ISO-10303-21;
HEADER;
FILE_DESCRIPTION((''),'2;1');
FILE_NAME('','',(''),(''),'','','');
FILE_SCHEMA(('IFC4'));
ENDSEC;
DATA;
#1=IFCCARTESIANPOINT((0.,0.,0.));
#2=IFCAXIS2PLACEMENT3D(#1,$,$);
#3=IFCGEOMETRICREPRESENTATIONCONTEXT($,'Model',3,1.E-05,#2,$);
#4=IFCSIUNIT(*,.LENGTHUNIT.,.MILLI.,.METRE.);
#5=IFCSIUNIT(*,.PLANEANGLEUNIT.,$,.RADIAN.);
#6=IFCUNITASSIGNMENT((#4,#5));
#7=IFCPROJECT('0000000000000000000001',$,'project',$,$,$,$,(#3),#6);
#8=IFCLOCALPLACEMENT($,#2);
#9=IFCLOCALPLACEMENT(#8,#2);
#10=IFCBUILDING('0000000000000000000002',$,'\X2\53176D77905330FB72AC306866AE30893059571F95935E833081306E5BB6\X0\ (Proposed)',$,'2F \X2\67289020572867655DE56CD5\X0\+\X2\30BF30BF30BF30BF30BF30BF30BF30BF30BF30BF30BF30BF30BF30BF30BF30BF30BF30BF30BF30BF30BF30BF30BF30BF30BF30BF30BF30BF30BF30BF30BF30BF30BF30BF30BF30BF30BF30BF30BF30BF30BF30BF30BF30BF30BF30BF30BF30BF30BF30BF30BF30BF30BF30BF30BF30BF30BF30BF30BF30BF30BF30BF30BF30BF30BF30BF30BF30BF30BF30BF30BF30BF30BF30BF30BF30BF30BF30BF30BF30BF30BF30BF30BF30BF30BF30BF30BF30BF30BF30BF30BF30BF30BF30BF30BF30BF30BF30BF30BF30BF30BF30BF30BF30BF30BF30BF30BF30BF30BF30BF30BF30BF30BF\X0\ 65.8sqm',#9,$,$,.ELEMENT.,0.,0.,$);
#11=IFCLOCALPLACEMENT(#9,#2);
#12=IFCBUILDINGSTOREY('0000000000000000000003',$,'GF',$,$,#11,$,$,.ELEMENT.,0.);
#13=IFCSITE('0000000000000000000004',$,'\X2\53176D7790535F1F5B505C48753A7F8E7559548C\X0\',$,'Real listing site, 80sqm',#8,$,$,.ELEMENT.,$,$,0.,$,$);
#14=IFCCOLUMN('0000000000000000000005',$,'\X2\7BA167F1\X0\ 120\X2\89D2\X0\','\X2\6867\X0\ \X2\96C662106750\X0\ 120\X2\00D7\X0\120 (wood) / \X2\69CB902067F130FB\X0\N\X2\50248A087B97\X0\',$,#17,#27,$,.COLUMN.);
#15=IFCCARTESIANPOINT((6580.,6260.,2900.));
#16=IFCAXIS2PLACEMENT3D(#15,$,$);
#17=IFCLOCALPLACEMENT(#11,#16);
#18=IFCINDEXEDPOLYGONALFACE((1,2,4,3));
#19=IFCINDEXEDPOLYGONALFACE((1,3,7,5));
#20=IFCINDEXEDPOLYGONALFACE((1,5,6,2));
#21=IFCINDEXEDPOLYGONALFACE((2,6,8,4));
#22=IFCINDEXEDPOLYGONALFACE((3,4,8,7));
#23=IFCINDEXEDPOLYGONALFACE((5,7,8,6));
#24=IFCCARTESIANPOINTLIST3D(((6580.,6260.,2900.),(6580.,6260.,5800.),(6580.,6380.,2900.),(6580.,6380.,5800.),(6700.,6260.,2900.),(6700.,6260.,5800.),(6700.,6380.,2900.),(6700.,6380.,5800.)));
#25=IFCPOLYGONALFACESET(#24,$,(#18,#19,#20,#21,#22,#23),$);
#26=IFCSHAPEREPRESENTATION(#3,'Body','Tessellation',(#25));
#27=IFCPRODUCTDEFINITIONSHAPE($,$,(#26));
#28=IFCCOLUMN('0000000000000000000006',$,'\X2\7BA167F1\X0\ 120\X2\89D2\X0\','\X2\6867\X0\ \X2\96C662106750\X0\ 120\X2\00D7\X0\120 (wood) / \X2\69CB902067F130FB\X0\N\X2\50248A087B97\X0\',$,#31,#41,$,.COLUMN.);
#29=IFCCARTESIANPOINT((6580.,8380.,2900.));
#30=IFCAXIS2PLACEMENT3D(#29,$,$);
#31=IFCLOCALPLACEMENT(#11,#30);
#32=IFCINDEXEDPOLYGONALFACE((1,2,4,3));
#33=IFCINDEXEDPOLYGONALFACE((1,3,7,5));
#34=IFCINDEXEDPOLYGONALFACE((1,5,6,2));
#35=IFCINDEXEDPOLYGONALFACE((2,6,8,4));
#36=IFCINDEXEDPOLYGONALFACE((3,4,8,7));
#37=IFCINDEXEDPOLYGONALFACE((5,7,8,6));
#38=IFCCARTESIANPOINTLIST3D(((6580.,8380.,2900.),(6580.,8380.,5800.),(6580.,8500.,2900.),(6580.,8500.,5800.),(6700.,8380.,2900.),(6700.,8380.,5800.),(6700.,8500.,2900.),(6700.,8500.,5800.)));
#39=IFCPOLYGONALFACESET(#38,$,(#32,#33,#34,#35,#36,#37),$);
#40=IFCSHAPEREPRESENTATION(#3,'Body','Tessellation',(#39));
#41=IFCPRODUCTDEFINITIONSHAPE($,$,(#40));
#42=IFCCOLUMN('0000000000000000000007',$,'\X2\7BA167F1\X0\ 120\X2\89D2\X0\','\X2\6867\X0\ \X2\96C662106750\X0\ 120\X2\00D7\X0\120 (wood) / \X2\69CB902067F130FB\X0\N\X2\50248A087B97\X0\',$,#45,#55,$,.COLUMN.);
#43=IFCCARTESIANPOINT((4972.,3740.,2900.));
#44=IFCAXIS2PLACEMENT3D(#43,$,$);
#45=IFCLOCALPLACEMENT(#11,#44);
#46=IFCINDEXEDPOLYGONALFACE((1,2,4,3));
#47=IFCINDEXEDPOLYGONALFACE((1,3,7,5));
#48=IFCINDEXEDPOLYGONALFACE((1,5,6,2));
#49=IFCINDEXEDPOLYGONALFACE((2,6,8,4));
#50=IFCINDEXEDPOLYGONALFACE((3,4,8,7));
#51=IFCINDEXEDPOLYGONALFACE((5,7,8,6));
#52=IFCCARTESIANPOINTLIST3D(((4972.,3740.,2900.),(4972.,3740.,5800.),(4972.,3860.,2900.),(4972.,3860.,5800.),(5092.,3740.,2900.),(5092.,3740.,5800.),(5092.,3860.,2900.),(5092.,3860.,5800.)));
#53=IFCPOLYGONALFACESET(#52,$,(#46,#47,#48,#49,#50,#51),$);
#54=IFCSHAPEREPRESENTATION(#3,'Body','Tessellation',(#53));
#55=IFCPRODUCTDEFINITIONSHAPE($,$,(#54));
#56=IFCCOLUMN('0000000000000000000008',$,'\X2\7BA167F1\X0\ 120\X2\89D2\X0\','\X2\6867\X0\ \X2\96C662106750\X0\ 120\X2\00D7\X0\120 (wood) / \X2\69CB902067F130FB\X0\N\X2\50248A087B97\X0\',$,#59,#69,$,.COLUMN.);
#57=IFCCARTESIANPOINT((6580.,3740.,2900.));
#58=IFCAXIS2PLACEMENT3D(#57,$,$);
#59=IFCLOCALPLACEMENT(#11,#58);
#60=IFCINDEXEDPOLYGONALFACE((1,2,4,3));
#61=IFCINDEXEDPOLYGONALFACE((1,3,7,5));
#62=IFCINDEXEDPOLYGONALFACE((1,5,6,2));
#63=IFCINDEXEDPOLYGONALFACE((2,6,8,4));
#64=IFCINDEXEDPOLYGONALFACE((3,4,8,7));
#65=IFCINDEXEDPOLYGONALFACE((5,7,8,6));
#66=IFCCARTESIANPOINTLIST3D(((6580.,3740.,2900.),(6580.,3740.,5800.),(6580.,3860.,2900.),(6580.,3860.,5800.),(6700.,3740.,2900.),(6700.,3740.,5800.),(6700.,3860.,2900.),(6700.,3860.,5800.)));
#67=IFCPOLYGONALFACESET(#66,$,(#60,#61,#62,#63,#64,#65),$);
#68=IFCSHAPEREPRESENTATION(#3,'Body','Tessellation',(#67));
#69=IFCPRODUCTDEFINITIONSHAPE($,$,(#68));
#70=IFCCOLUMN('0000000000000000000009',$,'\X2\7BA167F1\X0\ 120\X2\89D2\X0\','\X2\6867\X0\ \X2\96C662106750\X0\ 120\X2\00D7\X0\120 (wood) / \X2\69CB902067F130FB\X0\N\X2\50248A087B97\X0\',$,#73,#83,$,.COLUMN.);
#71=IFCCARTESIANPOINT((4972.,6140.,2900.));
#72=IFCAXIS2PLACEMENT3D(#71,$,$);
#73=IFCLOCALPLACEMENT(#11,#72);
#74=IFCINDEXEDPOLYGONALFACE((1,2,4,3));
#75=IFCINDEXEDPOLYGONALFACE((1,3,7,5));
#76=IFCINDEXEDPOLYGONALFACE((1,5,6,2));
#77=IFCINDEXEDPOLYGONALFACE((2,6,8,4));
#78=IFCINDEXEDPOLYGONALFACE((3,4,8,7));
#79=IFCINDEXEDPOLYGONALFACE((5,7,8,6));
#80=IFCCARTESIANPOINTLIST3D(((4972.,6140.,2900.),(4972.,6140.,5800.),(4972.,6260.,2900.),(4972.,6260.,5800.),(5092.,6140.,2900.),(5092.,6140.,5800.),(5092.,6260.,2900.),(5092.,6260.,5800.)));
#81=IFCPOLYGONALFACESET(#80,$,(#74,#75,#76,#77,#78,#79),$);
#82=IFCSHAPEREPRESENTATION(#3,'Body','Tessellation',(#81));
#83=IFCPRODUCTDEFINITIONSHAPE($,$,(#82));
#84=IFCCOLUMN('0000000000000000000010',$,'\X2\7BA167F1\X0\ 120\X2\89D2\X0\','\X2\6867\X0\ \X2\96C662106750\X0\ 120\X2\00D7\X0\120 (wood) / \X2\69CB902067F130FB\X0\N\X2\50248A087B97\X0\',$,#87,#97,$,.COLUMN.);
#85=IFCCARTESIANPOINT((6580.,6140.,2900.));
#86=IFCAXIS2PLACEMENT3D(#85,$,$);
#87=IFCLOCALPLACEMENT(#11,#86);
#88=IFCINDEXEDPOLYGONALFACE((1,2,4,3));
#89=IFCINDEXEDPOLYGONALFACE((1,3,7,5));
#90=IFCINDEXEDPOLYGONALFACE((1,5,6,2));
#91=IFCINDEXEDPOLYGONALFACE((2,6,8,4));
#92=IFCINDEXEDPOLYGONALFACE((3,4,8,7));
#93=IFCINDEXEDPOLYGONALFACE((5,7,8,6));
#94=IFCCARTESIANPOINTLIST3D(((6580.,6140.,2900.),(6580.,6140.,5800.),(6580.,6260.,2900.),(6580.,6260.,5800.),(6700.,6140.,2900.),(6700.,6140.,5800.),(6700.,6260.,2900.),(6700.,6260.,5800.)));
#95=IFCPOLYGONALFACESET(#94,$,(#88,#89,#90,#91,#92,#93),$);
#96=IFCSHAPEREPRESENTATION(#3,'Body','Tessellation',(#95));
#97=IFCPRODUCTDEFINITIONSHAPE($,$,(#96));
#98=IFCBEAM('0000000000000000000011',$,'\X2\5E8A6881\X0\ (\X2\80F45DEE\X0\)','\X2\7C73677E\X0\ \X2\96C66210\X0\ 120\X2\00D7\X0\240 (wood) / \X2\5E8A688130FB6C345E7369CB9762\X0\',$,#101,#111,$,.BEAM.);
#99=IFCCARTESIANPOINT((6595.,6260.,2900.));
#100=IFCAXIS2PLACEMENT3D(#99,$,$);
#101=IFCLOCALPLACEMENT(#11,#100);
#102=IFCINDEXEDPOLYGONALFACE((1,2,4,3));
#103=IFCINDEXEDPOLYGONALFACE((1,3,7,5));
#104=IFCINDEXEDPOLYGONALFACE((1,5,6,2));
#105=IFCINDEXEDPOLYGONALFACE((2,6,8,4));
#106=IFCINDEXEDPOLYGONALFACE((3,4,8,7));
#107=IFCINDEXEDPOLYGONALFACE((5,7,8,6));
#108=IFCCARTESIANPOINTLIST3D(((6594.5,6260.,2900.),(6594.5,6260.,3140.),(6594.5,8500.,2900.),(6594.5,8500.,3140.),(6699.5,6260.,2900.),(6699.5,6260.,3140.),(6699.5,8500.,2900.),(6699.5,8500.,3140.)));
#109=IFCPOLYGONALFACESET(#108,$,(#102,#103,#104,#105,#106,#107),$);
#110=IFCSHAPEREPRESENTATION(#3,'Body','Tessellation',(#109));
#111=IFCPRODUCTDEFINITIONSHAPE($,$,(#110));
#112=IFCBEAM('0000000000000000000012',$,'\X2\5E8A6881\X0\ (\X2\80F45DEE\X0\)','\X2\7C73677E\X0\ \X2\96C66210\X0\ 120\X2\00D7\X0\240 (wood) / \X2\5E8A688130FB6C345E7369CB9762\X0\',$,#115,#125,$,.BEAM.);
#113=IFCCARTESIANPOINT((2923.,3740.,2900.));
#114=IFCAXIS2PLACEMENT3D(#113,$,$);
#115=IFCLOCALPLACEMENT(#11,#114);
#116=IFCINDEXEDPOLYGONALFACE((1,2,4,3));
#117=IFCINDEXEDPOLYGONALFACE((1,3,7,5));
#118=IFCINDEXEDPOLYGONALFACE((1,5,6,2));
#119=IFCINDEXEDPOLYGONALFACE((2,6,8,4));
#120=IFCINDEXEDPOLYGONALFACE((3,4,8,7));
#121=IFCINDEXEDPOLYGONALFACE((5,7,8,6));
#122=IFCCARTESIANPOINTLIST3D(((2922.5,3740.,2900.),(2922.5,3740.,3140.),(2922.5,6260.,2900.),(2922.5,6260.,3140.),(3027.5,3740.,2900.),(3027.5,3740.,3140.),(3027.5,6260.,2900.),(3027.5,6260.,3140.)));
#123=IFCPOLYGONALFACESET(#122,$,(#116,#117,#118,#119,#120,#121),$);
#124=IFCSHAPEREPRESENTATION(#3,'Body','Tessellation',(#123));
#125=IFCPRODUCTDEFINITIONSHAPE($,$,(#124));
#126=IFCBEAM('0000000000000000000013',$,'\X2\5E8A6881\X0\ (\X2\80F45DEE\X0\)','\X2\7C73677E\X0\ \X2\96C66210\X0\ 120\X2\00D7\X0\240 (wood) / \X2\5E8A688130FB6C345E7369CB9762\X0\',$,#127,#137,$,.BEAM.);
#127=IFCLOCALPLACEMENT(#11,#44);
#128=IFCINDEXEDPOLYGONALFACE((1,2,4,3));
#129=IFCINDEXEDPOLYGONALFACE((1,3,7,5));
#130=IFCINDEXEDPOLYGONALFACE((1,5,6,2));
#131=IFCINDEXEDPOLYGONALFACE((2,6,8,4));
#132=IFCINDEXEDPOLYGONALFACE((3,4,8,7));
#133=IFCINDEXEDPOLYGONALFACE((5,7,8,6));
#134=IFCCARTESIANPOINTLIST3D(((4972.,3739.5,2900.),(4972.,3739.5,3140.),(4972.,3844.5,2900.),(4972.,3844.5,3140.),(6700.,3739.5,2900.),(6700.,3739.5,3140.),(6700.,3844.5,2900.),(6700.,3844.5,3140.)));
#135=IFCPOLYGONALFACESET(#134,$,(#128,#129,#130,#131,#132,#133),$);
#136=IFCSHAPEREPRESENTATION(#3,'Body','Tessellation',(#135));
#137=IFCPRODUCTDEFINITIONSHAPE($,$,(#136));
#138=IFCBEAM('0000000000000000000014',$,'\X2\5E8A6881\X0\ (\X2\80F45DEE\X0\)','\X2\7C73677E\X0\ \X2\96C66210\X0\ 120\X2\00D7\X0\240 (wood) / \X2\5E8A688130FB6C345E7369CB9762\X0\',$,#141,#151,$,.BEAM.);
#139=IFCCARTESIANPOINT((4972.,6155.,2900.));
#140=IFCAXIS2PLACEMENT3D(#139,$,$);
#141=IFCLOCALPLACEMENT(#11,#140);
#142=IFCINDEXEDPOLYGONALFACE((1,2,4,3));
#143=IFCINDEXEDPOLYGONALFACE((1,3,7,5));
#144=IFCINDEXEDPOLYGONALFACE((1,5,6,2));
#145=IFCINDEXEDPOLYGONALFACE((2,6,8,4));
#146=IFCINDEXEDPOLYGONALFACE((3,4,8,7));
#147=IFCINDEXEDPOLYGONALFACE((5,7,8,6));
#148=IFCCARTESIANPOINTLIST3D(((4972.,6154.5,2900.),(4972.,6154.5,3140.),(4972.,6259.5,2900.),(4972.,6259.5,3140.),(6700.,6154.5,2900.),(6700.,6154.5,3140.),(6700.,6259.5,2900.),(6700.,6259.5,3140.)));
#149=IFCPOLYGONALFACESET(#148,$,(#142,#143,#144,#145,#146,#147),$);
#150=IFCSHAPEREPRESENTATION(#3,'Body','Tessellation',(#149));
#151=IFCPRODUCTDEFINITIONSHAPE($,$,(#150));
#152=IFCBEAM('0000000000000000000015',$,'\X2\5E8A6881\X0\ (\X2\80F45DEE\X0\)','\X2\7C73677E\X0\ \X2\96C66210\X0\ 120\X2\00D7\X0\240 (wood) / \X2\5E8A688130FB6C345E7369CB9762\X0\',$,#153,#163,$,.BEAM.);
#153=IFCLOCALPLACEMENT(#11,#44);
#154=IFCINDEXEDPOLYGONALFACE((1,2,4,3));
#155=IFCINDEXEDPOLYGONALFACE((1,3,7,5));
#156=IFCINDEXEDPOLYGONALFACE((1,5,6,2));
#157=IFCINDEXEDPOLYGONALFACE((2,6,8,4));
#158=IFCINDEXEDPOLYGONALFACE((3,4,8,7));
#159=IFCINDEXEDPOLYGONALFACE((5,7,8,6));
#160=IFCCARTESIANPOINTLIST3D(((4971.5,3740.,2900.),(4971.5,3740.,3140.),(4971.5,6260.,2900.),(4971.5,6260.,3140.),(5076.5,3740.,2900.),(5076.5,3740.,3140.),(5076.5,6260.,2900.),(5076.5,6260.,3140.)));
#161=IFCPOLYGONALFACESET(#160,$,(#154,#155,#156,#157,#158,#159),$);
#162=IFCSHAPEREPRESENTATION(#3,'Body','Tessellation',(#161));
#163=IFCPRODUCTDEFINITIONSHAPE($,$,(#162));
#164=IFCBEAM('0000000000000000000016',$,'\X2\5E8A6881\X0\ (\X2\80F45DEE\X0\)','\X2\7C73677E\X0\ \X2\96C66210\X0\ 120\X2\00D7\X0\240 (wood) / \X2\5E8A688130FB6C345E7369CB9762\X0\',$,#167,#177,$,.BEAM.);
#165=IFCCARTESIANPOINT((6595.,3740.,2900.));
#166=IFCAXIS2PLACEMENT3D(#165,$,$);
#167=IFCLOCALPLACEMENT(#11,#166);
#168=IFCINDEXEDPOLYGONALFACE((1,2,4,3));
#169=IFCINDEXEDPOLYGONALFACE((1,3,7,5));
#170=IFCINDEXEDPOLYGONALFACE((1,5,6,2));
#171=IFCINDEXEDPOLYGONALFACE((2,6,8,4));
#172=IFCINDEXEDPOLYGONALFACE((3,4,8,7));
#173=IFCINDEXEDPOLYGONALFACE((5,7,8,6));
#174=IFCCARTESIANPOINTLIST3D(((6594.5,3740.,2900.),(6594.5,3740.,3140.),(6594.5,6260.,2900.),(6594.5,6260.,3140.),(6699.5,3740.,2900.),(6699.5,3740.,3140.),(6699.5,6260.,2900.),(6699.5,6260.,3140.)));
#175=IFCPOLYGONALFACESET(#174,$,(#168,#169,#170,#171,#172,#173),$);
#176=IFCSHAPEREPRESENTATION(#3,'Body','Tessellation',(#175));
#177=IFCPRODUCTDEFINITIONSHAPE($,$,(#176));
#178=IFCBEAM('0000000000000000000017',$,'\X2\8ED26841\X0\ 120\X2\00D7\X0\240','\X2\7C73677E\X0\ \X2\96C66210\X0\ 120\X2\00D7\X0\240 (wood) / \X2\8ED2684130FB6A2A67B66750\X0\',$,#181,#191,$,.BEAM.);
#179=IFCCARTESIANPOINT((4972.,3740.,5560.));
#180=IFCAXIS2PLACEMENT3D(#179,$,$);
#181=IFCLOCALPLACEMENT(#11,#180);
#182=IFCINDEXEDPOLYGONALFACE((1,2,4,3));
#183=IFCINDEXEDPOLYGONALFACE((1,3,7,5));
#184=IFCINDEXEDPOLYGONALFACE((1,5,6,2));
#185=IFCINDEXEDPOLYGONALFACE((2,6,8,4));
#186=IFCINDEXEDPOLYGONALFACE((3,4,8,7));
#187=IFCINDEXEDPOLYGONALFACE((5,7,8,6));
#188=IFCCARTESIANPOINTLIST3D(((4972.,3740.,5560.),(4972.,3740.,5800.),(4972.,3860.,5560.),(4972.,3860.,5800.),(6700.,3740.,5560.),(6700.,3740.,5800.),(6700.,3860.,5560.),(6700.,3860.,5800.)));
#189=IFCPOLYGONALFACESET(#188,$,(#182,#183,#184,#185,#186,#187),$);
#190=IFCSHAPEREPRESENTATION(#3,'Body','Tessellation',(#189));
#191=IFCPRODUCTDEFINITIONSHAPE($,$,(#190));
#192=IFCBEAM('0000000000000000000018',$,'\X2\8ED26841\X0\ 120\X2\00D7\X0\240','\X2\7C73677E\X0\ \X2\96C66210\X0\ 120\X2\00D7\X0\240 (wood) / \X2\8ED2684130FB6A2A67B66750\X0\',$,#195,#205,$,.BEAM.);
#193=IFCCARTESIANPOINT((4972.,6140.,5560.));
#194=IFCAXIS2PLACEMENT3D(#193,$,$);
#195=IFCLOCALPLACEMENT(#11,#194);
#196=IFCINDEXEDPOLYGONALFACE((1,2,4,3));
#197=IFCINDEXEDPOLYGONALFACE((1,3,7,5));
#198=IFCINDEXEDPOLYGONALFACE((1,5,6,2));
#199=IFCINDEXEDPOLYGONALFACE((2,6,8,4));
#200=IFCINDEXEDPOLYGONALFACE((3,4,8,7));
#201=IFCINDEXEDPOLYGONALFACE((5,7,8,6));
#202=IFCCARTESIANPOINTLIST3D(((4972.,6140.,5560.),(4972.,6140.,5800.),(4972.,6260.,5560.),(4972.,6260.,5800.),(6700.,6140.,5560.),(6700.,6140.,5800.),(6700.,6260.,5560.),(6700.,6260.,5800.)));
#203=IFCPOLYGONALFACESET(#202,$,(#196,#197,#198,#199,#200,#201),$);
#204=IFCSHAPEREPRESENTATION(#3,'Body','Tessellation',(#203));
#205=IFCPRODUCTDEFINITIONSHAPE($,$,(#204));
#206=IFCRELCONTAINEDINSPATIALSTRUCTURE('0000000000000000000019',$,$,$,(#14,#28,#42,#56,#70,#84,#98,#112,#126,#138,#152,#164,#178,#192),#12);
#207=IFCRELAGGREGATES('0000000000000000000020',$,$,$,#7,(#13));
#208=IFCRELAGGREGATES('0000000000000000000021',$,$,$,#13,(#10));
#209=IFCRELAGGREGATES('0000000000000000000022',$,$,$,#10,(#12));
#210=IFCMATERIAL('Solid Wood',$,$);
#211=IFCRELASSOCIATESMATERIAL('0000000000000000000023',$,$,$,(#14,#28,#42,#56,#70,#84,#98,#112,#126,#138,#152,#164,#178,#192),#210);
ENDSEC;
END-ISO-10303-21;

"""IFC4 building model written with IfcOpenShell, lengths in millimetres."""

from ifc_helpers import new_model, si_unit, frame, frame_2d, origin, place, context, project, spatial, rectangle, extrude, material, element, save


model = new_model("IFC4")

# Units and contexts
model_context = context("Model", 3, precision=1e-05, world=origin())
ifc_project = project(units=[si_unit("LENGTHUNIT", "METRE", prefix="MILLI"), si_unit("PLANEANGLEUNIT", "RADIAN")], contexts=[model_context])

# Site, building, storey
site_placement = place(None, origin())
site = spatial("IfcSite", under=ifc_project, at=site_placement, Name="北海道弟子屈町美留和", ObjectType="Real listing site, 80sqm", CompositionType="ELEMENT", RefElevation=0.0)
building_placement = place(site_placement, origin())
building = spatial("IfcBuilding", under=site, at=building_placement, Name="北海道・犬と暮らす土間広めの家 (Proposed)", ObjectType="2F 木造在来工法+タタタタタタタタタタタタタタタタタタタタタタタタタタタタタタタタタタタタタタタタタタタタタタタタタタタタタタタタタタタタタタタタタタタタタタタタタタタタタタタタタタタタタタタタタタタタタタタタタタタタタタタタタタタタタタタタタ 65.8sqm", CompositionType="ELEMENT", ElevationOfRefHeight=0.0, ElevationOfTerrain=0.0)
storey_placement = place(building_placement, origin())
storey = spatial("IfcBuildingStorey", under=building, at=storey_placement, Name="GF", CompositionType="ELEMENT", Elevation=0.0)

# Columns
ifc_material_1 = material(Name="Solid Wood")
column_1_placement = place(storey_placement, frame((6580.0, 6260.0, 2900.0)))
element("IfcColumn", 1, at=column_1_placement, inside=storey, material=ifc_material_1, Name="管柱 120角", Description="桧 集成材 120×120 (wood) / 構造柱・N値計算", PredefinedType="COLUMN", context=model_context, shape_type="SweptSolid", body=[
    extrude(rectangle(XDim=120.0, YDim=120.0, at=frame_2d((60.0, 60.0))), frame((6580.0, 6260.0, 2900.0)), (0.0, 0.0, 1.0), 2900.0),
])
column_2_placement = place(storey_placement, frame((6580.0, 8380.0, 2900.0)))
element("IfcColumn", 2, at=column_2_placement, inside=storey, material=ifc_material_1, Name="管柱 120角", Description="桧 集成材 120×120 (wood) / 構造柱・N値計算", PredefinedType="COLUMN", context=model_context, shape_type="SweptSolid", body=[
    extrude(rectangle(XDim=120.0, YDim=120.0, at=frame_2d((60.0, 60.0))), frame((6580.0, 8380.0, 2900.0)), (0.0, 0.0, 1.0), 2900.0),
])
column_3_placement = place(storey_placement, frame((4972.0, 3740.0, 2900.0)))
element("IfcColumn", 3, at=column_3_placement, inside=storey, material=ifc_material_1, Name="管柱 120角", Description="桧 集成材 120×120 (wood) / 構造柱・N値計算", PredefinedType="COLUMN", context=model_context, shape_type="SweptSolid", body=[
    extrude(rectangle(XDim=120.0, YDim=120.0, at=frame_2d((60.0, 60.0))), frame((4972.0, 3740.0, 2900.0)), (0.0, 0.0, 1.0), 2900.0),
])
column_4_placement = place(storey_placement, frame((6580.0, 3740.0, 2900.0)))
element("IfcColumn", 4, at=column_4_placement, inside=storey, material=ifc_material_1, Name="管柱 120角", Description="桧 集成材 120×120 (wood) / 構造柱・N値計算", PredefinedType="COLUMN", context=model_context, shape_type="SweptSolid", body=[
    extrude(rectangle(XDim=120.0, YDim=120.0, at=frame_2d((60.0, 60.0))), frame((6580.0, 3740.0, 2900.0)), (0.0, 0.0, 1.0), 2900.0),
])
column_5_placement = place(storey_placement, frame((4972.0, 6140.0, 2900.0)))
element("IfcColumn", 5, at=column_5_placement, inside=storey, material=ifc_material_1, Name="管柱 120角", Description="桧 集成材 120×120 (wood) / 構造柱・N値計算", PredefinedType="COLUMN", context=model_context, shape_type="SweptSolid", body=[
    extrude(rectangle(XDim=120.0, YDim=120.0, at=frame_2d((60.0, 60.0))), frame((4972.0, 6140.0, 2900.0)), (0.0, 0.0, 1.0), 2900.0),
])
column_6_placement = place(storey_placement, frame((6580.0, 6140.0, 2900.0)))
element("IfcColumn", 6, at=column_6_placement, inside=storey, material=ifc_material_1, Name="管柱 120角", Description="桧 集成材 120×120 (wood) / 構造柱・N値計算", PredefinedType="COLUMN", context=model_context, shape_type="SweptSolid", body=[
    extrude(rectangle(XDim=120.0, YDim=120.0, at=frame_2d((60.0, 60.0))), frame((6580.0, 6140.0, 2900.0)), (0.0, 0.0, 1.0), 2900.0),
])

# Beams
beam_1_placement = place(storey_placement, frame((6595.0, 6260.0, 2900.0)))
element("IfcBeam", 7, at=beam_1_placement, inside=storey, material=ifc_material_1, Name="床梁 (胴差)", Description="米松 集成 120×240 (wood) / 床梁・水平構面", PredefinedType="BEAM", context=model_context, shape_type="SweptSolid", body=[
    extrude(rectangle(XDim=105.0, YDim=2240.0, at=frame_2d((52.0, 1120.0))), frame((6595.0, 6260.0, 2900.0)), (0.0, 0.0, 1.0), 240.0),
])
beam_2_placement = place(storey_placement, frame((2923.0, 3740.0, 2900.0)))
element("IfcBeam", 8, at=beam_2_placement, inside=storey, material=ifc_material_1, Name="床梁 (胴差)", Description="米松 集成 120×240 (wood) / 床梁・水平構面", PredefinedType="BEAM", context=model_context, shape_type="SweptSolid", body=[
    extrude(rectangle(XDim=105.0, YDim=2520.0, at=frame_2d((52.0, 1260.0))), frame((2923.0, 3740.0, 2900.0)), (0.0, 0.0, 1.0), 240.0),
])
beam_3_placement = place(storey_placement, frame((4972.0, 3740.0, 2900.0)))
element("IfcBeam", 9, at=beam_3_placement, inside=storey, material=ifc_material_1, Name="床梁 (胴差)", Description="米松 集成 120×240 (wood) / 床梁・水平構面", PredefinedType="BEAM", context=model_context, shape_type="SweptSolid", body=[
    extrude(rectangle(XDim=1728.0, YDim=105.0, at=frame_2d((864.0, 52.0))), frame((4972.0, 3740.0, 2900.0)), (0.0, 0.0, 1.0), 240.0),
])
beam_4_placement = place(storey_placement, frame((4972.0, 6155.0, 2900.0)))
element("IfcBeam", 10, at=beam_4_placement, inside=storey, material=ifc_material_1, Name="床梁 (胴差)", Description="米松 集成 120×240 (wood) / 床梁・水平構面", PredefinedType="BEAM", context=model_context, shape_type="SweptSolid", body=[
    extrude(rectangle(XDim=1728.0, YDim=105.0, at=frame_2d((864.0, 52.0))), frame((4972.0, 6155.0, 2900.0)), (0.0, 0.0, 1.0), 240.0),
])
beam_5_placement = place(storey_placement, frame((4972.0, 3740.0, 2900.0)))
element("IfcBeam", 11, at=beam_5_placement, inside=storey, material=ifc_material_1, Name="床梁 (胴差)", Description="米松 集成 120×240 (wood) / 床梁・水平構面", PredefinedType="BEAM", context=model_context, shape_type="SweptSolid", body=[
    extrude(rectangle(XDim=105.0, YDim=2520.0, at=frame_2d((52.0, 1260.0))), frame((4972.0, 3740.0, 2900.0)), (0.0, 0.0, 1.0), 240.0),
])
beam_6_placement = place(storey_placement, frame((6595.0, 3740.0, 2900.0)))
element("IfcBeam", 12, at=beam_6_placement, inside=storey, material=ifc_material_1, Name="床梁 (胴差)", Description="米松 集成 120×240 (wood) / 床梁・水平構面", PredefinedType="BEAM", context=model_context, shape_type="SweptSolid", body=[
    extrude(rectangle(XDim=105.0, YDim=2520.0, at=frame_2d((52.0, 1260.0))), frame((6595.0, 3740.0, 2900.0)), (0.0, 0.0, 1.0), 240.0),
])
beam_7_placement = place(storey_placement, frame((4972.0, 3740.0, 5560.0)))
element("IfcBeam", 13, at=beam_7_placement, inside=storey, material=ifc_material_1, Name="軒桁 120×240", Description="米松 集成 120×240 (wood) / 軒桁・横架材", PredefinedType="BEAM", context=model_context, shape_type="SweptSolid", body=[
    extrude(rectangle(XDim=1728.0, YDim=120.0, at=frame_2d((864.0, 60.0))), frame((4972.0, 3740.0, 5560.0)), (0.0, 0.0, 1.0), 240.0),
])
beam_8_placement = place(storey_placement, frame((4972.0, 6140.0, 5560.0)))
element("IfcBeam", 14, at=beam_8_placement, inside=storey, material=ifc_material_1, Name="軒桁 120×240", Description="米松 集成 120×240 (wood) / 軒桁・横架材", PredefinedType="BEAM", context=model_context, shape_type="SweptSolid", body=[
    extrude(rectangle(XDim=1728.0, YDim=120.0, at=frame_2d((864.0, 60.0))), frame((4972.0, 6140.0, 5560.0)), (0.0, 0.0, 1.0), 240.0),
])

save(model, "model.ifc")
